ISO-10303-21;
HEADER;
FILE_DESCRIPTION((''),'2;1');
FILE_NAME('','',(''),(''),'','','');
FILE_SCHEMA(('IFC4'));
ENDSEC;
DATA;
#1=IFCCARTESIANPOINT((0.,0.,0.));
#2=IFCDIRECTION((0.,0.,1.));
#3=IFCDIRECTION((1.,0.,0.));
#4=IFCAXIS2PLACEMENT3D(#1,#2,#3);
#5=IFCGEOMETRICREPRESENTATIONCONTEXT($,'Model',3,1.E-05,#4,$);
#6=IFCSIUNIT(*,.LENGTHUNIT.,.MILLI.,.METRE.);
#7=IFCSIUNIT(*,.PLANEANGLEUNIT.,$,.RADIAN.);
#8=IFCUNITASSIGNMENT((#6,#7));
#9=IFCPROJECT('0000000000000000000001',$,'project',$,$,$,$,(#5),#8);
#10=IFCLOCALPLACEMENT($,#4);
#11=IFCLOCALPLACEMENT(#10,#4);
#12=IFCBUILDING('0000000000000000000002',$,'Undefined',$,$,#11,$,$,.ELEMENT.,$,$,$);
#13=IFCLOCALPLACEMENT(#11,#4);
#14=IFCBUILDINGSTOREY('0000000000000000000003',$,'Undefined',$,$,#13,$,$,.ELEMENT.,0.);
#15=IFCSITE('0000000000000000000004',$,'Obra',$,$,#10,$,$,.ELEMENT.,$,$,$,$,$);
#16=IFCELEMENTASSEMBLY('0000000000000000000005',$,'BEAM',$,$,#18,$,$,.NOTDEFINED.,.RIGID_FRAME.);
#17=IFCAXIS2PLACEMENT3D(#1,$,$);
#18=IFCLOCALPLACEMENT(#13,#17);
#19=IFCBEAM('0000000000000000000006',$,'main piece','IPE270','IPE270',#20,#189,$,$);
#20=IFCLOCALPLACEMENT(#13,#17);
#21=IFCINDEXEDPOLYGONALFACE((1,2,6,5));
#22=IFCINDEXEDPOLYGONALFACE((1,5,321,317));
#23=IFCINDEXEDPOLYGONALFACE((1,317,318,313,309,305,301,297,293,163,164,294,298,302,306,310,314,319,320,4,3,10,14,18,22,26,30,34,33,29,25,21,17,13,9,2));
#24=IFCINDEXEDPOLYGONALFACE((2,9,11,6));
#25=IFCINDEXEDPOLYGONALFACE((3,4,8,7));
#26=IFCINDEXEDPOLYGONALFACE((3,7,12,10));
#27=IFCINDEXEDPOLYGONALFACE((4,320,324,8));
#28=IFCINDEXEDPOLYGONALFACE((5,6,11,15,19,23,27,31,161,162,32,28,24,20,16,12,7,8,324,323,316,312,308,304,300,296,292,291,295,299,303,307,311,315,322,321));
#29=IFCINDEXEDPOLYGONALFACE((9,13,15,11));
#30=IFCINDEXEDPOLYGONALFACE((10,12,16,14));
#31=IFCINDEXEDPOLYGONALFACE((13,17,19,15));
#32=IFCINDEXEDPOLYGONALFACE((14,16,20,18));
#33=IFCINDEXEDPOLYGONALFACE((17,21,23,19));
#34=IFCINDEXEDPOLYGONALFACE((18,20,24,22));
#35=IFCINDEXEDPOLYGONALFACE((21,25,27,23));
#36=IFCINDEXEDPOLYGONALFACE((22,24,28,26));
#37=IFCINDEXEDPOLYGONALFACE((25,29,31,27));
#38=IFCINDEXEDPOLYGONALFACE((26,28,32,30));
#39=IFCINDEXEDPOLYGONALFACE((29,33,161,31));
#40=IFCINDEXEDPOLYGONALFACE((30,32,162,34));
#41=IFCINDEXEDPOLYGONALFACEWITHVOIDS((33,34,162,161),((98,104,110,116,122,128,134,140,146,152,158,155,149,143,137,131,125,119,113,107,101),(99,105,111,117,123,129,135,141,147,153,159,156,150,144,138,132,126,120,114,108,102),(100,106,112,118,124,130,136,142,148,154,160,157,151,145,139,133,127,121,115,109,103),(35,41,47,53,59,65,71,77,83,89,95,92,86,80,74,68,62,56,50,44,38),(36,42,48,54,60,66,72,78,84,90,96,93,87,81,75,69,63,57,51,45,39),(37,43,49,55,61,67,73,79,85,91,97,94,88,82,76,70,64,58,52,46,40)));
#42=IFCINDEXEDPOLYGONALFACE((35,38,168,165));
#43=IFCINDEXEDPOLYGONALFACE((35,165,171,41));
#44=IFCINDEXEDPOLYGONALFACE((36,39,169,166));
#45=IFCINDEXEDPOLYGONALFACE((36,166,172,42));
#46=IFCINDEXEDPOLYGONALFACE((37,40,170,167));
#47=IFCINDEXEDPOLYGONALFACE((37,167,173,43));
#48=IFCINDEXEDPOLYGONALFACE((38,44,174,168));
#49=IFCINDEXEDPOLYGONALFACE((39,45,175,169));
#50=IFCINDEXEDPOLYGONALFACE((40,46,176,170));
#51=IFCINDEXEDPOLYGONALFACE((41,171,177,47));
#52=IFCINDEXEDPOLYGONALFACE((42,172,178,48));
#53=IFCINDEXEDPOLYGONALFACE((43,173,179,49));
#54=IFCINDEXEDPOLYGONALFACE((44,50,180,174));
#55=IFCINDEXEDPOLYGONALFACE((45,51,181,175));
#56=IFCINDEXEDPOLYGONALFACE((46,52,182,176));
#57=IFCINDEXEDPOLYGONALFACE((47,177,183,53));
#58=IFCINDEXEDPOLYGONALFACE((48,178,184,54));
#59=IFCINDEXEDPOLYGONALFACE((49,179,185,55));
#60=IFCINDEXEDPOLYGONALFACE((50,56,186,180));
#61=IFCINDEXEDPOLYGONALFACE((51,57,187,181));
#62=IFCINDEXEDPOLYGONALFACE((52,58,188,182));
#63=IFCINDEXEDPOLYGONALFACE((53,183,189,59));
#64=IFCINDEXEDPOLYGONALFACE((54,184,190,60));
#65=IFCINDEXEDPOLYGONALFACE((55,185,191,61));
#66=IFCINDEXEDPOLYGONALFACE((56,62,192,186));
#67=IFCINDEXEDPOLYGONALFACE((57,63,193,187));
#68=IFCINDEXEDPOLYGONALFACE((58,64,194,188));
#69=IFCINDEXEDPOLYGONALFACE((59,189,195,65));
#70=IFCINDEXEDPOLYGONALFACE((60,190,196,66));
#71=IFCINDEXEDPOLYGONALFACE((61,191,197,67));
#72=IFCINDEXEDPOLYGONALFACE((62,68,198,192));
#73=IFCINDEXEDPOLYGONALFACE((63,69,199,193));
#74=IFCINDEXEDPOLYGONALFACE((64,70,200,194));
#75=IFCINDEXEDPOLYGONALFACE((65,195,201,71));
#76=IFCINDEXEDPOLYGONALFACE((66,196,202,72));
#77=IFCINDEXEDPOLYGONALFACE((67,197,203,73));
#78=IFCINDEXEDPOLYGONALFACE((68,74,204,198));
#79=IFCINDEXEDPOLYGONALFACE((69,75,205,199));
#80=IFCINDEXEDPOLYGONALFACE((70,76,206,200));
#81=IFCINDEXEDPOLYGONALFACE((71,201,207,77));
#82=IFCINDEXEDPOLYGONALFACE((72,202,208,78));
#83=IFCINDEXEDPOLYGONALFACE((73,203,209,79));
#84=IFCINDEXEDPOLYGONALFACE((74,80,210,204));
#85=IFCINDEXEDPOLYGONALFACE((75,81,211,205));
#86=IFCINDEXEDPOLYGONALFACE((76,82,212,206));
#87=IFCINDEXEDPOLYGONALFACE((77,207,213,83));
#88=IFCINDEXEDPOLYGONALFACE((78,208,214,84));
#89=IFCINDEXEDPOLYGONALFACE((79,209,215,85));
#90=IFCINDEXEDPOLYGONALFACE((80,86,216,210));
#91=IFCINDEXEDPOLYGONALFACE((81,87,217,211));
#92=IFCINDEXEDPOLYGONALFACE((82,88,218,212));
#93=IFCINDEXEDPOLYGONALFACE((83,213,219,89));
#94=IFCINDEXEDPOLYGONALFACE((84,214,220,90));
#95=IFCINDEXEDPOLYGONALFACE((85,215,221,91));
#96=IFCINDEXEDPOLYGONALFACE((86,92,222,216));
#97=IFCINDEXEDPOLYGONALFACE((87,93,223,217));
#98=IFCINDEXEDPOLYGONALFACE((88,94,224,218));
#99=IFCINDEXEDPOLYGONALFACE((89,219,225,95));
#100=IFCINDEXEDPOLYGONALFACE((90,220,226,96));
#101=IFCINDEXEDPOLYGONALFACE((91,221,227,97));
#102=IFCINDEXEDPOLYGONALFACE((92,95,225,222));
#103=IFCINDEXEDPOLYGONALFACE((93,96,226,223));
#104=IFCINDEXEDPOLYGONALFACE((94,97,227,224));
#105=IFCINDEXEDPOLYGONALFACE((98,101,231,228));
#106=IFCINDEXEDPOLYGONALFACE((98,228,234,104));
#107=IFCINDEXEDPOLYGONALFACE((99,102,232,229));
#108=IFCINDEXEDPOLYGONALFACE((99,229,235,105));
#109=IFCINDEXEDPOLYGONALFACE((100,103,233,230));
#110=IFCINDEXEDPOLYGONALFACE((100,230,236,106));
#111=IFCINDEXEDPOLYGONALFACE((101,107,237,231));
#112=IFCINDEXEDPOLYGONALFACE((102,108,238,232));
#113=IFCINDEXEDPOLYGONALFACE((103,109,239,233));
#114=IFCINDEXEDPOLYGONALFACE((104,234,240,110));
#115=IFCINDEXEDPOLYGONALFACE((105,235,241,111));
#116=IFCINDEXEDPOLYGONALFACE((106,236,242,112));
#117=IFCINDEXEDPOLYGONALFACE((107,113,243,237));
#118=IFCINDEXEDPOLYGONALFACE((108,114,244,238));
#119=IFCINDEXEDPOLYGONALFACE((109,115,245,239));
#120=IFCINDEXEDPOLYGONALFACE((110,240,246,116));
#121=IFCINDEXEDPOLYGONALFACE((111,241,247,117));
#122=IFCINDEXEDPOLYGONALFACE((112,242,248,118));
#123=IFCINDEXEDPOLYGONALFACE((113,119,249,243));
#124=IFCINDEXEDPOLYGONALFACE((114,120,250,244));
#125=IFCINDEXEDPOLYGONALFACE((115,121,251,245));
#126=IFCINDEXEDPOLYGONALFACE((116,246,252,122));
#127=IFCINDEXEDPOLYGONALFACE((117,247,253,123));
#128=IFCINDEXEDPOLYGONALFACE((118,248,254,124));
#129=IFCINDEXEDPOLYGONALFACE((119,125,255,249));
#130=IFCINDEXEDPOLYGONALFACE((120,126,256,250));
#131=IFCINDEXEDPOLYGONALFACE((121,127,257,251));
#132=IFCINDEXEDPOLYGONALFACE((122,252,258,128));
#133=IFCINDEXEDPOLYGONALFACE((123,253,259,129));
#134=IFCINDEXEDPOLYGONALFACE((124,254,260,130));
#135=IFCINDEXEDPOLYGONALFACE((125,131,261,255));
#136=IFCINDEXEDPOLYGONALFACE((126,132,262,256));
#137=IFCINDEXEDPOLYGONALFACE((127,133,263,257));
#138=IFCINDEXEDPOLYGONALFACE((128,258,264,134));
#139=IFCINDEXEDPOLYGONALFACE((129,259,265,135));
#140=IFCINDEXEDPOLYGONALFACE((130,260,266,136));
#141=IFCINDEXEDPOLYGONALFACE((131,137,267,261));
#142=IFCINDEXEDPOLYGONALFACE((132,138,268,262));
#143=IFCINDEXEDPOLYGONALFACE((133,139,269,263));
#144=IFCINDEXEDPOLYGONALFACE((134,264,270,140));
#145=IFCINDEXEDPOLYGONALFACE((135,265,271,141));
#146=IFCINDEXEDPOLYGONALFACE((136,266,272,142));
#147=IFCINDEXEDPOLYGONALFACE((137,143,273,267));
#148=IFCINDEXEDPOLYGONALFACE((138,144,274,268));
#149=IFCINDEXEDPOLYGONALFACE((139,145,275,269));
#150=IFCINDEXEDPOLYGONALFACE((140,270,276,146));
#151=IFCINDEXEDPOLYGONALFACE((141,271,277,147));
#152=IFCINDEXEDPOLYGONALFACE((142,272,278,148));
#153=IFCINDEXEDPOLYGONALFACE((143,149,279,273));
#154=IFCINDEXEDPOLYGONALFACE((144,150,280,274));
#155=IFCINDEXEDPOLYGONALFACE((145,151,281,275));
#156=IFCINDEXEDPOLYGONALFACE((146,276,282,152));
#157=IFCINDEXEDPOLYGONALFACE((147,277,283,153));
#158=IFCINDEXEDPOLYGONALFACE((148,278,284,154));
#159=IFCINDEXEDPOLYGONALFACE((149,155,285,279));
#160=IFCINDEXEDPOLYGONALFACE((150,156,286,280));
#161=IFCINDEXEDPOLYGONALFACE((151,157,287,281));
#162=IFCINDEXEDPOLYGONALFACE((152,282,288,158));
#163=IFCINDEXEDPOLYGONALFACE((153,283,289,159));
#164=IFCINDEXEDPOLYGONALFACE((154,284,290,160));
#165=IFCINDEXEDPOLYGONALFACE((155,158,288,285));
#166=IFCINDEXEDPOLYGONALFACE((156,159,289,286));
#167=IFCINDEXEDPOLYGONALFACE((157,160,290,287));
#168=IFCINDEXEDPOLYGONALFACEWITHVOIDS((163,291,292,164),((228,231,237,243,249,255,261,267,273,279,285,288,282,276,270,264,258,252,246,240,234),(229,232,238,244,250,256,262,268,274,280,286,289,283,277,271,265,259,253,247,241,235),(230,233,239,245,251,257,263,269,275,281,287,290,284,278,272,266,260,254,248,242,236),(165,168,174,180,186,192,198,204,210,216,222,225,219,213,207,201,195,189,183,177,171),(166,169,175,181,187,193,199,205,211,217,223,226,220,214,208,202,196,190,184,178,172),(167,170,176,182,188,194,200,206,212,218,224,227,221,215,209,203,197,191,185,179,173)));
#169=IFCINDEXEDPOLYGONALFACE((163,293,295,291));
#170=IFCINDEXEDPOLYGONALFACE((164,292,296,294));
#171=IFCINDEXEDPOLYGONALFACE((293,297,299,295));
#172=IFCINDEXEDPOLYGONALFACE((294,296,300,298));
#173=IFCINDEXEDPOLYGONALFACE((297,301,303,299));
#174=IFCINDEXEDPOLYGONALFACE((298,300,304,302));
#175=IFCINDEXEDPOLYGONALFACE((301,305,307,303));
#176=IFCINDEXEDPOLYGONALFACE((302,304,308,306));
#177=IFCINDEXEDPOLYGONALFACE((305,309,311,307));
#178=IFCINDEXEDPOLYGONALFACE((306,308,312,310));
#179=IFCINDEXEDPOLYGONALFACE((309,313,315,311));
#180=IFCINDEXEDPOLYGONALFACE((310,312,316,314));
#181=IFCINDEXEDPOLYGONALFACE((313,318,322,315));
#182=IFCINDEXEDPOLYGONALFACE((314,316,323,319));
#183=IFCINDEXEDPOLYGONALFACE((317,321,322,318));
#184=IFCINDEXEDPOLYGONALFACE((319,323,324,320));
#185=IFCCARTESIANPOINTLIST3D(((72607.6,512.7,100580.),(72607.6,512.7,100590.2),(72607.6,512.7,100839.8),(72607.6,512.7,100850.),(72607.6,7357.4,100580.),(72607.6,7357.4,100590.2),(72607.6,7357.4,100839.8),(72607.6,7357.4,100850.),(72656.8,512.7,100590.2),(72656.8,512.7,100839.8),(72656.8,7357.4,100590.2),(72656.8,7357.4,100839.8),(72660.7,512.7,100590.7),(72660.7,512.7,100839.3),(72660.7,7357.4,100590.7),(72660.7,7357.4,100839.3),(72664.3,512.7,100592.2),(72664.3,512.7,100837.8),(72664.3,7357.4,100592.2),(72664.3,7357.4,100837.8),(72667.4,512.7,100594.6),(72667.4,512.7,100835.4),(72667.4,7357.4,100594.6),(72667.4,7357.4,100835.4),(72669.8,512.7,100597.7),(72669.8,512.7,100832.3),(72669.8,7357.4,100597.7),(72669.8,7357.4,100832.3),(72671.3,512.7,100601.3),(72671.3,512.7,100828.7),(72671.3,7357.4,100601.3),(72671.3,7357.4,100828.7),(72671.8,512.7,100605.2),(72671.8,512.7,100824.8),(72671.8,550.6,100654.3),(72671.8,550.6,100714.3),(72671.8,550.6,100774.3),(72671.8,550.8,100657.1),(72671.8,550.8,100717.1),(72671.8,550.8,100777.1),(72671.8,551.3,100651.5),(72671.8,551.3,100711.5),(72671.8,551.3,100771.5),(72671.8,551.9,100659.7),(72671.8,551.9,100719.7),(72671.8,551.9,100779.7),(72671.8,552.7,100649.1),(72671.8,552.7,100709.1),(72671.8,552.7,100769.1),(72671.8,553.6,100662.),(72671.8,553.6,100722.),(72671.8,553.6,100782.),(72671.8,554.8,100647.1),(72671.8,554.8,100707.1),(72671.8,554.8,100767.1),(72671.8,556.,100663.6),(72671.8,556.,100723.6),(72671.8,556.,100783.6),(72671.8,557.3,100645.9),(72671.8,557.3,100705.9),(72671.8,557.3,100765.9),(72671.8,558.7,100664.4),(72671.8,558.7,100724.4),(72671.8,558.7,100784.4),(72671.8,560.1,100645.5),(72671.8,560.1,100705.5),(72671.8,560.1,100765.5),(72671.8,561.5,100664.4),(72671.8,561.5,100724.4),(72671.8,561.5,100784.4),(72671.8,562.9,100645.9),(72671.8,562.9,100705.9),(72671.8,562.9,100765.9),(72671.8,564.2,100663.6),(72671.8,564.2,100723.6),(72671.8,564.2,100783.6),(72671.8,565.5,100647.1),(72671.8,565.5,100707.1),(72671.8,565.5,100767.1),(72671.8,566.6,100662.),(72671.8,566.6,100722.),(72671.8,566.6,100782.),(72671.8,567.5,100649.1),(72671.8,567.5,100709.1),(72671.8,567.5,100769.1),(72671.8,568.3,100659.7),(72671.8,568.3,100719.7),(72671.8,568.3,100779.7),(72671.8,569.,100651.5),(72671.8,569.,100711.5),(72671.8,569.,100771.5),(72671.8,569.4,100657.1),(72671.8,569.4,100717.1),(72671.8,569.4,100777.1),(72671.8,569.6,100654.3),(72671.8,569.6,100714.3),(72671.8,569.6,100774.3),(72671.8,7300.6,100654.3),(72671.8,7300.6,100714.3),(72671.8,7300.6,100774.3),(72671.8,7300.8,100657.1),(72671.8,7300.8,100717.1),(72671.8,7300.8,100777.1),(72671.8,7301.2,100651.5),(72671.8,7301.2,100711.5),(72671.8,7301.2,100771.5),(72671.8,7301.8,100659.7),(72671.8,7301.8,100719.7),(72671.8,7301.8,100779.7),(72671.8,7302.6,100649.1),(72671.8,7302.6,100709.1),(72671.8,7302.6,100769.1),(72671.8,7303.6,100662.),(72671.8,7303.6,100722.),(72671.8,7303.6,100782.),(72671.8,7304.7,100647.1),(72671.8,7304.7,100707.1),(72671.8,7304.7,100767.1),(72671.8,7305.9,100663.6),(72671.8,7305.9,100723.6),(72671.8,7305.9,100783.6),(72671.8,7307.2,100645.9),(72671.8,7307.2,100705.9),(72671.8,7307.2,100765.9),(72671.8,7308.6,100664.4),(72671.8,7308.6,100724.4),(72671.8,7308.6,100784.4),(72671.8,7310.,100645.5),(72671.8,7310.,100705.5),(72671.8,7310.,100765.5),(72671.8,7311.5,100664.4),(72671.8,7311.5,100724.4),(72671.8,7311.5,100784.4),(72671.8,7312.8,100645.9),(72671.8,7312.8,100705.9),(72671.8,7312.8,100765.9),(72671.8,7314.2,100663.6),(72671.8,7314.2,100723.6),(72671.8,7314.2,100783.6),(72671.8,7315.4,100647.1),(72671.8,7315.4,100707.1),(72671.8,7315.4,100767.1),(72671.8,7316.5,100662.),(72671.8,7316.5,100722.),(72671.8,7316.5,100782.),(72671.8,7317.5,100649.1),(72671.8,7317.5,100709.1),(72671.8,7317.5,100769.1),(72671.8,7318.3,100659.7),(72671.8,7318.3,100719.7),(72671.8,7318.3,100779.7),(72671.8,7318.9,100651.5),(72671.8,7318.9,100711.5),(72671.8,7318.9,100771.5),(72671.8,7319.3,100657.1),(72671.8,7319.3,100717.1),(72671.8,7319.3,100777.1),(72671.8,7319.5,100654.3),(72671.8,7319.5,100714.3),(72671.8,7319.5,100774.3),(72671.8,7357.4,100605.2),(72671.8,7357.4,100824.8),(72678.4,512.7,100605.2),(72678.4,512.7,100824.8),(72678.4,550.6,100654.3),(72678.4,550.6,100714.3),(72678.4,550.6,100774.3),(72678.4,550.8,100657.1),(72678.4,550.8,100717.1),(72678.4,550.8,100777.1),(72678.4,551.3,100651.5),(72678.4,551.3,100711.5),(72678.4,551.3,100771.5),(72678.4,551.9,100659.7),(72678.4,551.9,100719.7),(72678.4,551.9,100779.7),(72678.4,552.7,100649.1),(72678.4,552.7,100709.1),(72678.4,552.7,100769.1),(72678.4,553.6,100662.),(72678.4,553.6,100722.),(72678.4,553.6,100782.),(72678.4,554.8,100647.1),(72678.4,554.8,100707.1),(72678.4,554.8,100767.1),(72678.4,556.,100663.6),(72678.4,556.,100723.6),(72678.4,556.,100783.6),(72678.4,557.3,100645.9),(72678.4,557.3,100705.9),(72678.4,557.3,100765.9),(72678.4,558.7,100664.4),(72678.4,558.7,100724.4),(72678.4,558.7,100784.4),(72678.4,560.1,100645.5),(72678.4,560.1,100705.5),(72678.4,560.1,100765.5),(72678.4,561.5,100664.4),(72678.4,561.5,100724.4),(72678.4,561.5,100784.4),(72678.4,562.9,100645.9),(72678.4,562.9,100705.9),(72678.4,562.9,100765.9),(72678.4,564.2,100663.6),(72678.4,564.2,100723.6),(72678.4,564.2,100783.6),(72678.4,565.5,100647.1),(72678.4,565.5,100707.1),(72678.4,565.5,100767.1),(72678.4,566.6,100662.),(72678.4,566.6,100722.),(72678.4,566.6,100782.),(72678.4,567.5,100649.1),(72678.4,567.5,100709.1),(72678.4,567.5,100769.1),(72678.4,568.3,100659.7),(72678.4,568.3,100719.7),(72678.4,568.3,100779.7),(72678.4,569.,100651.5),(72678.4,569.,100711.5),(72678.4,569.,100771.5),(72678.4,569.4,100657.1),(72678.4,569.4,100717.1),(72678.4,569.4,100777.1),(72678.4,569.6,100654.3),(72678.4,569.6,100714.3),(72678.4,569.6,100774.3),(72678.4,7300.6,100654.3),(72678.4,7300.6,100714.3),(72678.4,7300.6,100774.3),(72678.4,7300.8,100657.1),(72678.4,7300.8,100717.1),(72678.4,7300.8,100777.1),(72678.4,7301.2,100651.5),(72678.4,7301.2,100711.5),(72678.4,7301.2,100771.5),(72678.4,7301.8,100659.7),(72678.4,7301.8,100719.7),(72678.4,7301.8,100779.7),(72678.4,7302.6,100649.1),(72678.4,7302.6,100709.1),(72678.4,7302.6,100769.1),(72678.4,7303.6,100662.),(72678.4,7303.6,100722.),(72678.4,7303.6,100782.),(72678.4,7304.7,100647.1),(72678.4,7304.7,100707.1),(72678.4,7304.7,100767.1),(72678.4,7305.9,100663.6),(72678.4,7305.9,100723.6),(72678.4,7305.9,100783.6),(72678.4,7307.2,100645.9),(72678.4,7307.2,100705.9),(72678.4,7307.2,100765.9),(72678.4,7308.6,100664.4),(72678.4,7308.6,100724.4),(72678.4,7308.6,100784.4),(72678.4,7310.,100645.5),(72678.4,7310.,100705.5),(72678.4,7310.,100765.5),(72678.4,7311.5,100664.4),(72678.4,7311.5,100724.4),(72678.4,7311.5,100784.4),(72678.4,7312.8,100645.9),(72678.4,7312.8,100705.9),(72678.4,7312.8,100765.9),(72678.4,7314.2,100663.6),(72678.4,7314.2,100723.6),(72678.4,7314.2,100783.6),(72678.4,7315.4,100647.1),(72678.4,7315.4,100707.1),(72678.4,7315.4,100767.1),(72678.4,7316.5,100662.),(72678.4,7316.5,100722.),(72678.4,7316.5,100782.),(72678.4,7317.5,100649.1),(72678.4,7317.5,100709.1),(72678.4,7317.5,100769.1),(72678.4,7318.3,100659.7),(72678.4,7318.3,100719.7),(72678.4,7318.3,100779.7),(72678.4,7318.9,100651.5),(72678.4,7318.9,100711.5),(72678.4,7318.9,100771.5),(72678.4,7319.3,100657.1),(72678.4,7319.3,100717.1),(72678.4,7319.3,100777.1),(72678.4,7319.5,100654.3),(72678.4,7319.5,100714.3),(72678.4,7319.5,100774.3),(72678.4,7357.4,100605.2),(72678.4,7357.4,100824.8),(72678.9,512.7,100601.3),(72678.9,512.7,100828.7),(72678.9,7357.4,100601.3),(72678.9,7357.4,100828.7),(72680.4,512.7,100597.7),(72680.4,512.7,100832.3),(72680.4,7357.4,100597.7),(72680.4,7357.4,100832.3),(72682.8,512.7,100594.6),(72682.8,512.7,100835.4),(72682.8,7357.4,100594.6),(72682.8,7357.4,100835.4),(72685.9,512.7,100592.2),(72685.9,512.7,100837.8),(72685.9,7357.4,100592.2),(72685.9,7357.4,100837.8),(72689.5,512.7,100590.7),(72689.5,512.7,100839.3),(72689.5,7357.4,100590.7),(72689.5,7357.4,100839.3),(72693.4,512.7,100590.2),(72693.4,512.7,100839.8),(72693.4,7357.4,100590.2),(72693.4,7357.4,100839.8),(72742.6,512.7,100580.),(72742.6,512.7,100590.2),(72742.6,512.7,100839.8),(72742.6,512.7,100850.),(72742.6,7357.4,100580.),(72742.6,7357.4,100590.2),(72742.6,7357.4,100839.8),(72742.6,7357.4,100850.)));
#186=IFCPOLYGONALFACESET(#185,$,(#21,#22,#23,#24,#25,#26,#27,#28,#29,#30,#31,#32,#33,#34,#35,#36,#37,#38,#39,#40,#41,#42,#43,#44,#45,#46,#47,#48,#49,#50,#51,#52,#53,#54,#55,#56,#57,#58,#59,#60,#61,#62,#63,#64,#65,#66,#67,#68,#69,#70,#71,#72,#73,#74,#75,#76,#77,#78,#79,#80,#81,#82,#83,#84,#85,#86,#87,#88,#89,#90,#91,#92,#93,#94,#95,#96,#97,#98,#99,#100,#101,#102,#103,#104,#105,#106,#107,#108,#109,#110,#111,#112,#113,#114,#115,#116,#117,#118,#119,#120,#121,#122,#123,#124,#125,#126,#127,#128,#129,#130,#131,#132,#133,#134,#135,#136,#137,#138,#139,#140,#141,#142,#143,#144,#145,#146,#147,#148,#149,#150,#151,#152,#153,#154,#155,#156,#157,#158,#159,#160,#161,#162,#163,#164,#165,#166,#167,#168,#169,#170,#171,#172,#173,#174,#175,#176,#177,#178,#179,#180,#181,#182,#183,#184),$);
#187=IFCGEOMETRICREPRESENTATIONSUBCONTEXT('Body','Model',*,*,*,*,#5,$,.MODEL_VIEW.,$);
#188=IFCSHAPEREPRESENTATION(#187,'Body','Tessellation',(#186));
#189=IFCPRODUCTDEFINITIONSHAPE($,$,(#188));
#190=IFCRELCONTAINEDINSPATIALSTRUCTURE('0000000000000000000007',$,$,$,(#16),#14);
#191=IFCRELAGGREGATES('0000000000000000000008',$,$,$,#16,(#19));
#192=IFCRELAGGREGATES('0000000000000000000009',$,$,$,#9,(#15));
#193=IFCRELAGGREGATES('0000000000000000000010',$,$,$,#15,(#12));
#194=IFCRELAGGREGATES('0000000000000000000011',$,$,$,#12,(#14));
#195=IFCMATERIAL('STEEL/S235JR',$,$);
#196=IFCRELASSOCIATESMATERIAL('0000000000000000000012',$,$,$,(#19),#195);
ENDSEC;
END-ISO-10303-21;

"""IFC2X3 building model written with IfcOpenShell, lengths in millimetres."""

from ifc_helpers import new_model, si_unit, frame, origin_with_axes, origin_2d_with_axis, place, context, subcontext, project, spatial, circle, i_section, extrude, clip, halfspace, source, transform, mapped, material, element, aggregate, save


model = new_model("IFC2X3")

# Units and contexts
model_context = context("Model", 3, precision=1e-05, world=origin_with_axes())
body_context = subcontext(model_context, "Body", "Model", "MODEL_VIEW")
ifc_project = project(units=[si_unit("LENGTHUNIT", "METRE", prefix="MILLI"), si_unit("PLANEANGLEUNIT", "RADIAN")], contexts=[model_context])

# Site, building, storey
site_placement = place(None, origin_with_axes())
site = spatial("IfcSite", under=ifc_project, at=site_placement, Name="Obra", CompositionType="ELEMENT")
building_placement = place(site_placement, origin_with_axes())
building = spatial("IfcBuilding", under=site, at=building_placement, Name="Undefined", CompositionType="ELEMENT")
storey_placement = place(building_placement, origin_with_axes())
storey = spatial("IfcBuildingStorey", under=building, at=storey_placement, Name="Undefined", CompositionType="ELEMENT", Elevation=0.0)

# Element assembly, beam, openings
ifc_material = material(Name="STEEL/S235JR")
assembly_1_placement = place(storey_placement, origin_with_axes())
assembly_1 = element("IfcElementAssembly", 1, at=assembly_1_placement, inside=storey, Name="BEAM", AssemblyPlace="NOTDEFINED", PredefinedType="RIGID_FRAME")
beam_1_placement = place(assembly_1_placement, frame((72675.1, 512.7, 100715.0), z_axis=(0.0, 0.0, 1.0), x_axis=(0.0, 1.0, 0.0)))
beam_1 = element("IfcBeam", 2, at=beam_1_placement, material=ifc_material, Name="main piece", Description="IPE270", ObjectType="IPE270", context=body_context, shape_type="Clipping", body=[
    clip(clip(extrude(i_section(OverallWidth=135.0, OverallDepth=270.0, WebThickness=6.6, FlangeThickness=10.2, FilletRadius=15.0, at=origin_2d_with_axis()), frame((6844.7, 0.0, 0.0), z_axis=(-1.0, 0.0, 0.0), x_axis=(0.0, -1.0, 0.0)), (0.0, 0.0, 1.0), 6844.7), halfspace(frame((-2.2, 60.0, -120.0), z_axis=(-1.0, -0.000021, 0.0), x_axis=(0.0, 0.0, 1.0)), False)), halfspace(frame((6846.8, -60.0, -120.0), z_axis=(1.0, 0.0, 0.0), x_axis=(0.0, 0.0, 1.0)), False)),
])
shared_shape_1 = source(origin_with_axes(), body_context, "Body", "SweptSolid", [
    extrude(circle(Radius=9.5, at=origin_2d_with_axis()), frame((0.0, -3.4, 0.0), z_axis=(0.0, 1.0, 0.0), x_axis=(1.0, 0.0, 0.0)), (0.0, 0.0, 1.0), 6.8),
])
opening_1_placement = place(assembly_1_placement, frame((72675.1, 510.1, 100835.0), z_axis=(-0.000002, 1.0, 0.0), x_axis=(0.0, 0.0, -1.0)))
element("IfcOpeningElement", 3, at=opening_1_placement, cuts=beam_1, ObjectType="Opening", context=body_context, shape_type="MappedRepresentation", body=[
    mapped(shared_shape_1, transform((60.0, 0.0, 50.0))),
    mapped(shared_shape_1, transform((120.0, 0.0, 50.0))),
    mapped(shared_shape_1, transform((180.0, 0.0, 50.0))),
])
shared_shape_2 = source(origin_with_axes(), body_context, "Body", "SweptSolid", [
    extrude(circle(Radius=9.5, at=origin_2d_with_axis()), frame((0.0, -3.4, 0.0), z_axis=(0.0, 1.0, 0.0), x_axis=(1.0, 0.0, 0.0)), (0.0, 0.0, 1.0), 6.8),
])
opening_2_placement = place(assembly_1_placement, frame((72675.1, 7360.0, 100835.0), z_axis=(-0.000019, -1.0, 0.0), x_axis=(0.0, 0.0, -1.0)))
element("IfcOpeningElement", 4, at=opening_2_placement, cuts=beam_1, ObjectType="Opening", context=body_context, shape_type="MappedRepresentation", body=[
    mapped(shared_shape_2, transform((60.0, 0.0, 50.0))),
    mapped(shared_shape_2, transform((120.0, 0.0, 50.0))),
    mapped(shared_shape_2, transform((180.0, 0.0, 50.0))),
])
aggregate(assembly_1, [beam_1])

save(model, "model.ifc")
